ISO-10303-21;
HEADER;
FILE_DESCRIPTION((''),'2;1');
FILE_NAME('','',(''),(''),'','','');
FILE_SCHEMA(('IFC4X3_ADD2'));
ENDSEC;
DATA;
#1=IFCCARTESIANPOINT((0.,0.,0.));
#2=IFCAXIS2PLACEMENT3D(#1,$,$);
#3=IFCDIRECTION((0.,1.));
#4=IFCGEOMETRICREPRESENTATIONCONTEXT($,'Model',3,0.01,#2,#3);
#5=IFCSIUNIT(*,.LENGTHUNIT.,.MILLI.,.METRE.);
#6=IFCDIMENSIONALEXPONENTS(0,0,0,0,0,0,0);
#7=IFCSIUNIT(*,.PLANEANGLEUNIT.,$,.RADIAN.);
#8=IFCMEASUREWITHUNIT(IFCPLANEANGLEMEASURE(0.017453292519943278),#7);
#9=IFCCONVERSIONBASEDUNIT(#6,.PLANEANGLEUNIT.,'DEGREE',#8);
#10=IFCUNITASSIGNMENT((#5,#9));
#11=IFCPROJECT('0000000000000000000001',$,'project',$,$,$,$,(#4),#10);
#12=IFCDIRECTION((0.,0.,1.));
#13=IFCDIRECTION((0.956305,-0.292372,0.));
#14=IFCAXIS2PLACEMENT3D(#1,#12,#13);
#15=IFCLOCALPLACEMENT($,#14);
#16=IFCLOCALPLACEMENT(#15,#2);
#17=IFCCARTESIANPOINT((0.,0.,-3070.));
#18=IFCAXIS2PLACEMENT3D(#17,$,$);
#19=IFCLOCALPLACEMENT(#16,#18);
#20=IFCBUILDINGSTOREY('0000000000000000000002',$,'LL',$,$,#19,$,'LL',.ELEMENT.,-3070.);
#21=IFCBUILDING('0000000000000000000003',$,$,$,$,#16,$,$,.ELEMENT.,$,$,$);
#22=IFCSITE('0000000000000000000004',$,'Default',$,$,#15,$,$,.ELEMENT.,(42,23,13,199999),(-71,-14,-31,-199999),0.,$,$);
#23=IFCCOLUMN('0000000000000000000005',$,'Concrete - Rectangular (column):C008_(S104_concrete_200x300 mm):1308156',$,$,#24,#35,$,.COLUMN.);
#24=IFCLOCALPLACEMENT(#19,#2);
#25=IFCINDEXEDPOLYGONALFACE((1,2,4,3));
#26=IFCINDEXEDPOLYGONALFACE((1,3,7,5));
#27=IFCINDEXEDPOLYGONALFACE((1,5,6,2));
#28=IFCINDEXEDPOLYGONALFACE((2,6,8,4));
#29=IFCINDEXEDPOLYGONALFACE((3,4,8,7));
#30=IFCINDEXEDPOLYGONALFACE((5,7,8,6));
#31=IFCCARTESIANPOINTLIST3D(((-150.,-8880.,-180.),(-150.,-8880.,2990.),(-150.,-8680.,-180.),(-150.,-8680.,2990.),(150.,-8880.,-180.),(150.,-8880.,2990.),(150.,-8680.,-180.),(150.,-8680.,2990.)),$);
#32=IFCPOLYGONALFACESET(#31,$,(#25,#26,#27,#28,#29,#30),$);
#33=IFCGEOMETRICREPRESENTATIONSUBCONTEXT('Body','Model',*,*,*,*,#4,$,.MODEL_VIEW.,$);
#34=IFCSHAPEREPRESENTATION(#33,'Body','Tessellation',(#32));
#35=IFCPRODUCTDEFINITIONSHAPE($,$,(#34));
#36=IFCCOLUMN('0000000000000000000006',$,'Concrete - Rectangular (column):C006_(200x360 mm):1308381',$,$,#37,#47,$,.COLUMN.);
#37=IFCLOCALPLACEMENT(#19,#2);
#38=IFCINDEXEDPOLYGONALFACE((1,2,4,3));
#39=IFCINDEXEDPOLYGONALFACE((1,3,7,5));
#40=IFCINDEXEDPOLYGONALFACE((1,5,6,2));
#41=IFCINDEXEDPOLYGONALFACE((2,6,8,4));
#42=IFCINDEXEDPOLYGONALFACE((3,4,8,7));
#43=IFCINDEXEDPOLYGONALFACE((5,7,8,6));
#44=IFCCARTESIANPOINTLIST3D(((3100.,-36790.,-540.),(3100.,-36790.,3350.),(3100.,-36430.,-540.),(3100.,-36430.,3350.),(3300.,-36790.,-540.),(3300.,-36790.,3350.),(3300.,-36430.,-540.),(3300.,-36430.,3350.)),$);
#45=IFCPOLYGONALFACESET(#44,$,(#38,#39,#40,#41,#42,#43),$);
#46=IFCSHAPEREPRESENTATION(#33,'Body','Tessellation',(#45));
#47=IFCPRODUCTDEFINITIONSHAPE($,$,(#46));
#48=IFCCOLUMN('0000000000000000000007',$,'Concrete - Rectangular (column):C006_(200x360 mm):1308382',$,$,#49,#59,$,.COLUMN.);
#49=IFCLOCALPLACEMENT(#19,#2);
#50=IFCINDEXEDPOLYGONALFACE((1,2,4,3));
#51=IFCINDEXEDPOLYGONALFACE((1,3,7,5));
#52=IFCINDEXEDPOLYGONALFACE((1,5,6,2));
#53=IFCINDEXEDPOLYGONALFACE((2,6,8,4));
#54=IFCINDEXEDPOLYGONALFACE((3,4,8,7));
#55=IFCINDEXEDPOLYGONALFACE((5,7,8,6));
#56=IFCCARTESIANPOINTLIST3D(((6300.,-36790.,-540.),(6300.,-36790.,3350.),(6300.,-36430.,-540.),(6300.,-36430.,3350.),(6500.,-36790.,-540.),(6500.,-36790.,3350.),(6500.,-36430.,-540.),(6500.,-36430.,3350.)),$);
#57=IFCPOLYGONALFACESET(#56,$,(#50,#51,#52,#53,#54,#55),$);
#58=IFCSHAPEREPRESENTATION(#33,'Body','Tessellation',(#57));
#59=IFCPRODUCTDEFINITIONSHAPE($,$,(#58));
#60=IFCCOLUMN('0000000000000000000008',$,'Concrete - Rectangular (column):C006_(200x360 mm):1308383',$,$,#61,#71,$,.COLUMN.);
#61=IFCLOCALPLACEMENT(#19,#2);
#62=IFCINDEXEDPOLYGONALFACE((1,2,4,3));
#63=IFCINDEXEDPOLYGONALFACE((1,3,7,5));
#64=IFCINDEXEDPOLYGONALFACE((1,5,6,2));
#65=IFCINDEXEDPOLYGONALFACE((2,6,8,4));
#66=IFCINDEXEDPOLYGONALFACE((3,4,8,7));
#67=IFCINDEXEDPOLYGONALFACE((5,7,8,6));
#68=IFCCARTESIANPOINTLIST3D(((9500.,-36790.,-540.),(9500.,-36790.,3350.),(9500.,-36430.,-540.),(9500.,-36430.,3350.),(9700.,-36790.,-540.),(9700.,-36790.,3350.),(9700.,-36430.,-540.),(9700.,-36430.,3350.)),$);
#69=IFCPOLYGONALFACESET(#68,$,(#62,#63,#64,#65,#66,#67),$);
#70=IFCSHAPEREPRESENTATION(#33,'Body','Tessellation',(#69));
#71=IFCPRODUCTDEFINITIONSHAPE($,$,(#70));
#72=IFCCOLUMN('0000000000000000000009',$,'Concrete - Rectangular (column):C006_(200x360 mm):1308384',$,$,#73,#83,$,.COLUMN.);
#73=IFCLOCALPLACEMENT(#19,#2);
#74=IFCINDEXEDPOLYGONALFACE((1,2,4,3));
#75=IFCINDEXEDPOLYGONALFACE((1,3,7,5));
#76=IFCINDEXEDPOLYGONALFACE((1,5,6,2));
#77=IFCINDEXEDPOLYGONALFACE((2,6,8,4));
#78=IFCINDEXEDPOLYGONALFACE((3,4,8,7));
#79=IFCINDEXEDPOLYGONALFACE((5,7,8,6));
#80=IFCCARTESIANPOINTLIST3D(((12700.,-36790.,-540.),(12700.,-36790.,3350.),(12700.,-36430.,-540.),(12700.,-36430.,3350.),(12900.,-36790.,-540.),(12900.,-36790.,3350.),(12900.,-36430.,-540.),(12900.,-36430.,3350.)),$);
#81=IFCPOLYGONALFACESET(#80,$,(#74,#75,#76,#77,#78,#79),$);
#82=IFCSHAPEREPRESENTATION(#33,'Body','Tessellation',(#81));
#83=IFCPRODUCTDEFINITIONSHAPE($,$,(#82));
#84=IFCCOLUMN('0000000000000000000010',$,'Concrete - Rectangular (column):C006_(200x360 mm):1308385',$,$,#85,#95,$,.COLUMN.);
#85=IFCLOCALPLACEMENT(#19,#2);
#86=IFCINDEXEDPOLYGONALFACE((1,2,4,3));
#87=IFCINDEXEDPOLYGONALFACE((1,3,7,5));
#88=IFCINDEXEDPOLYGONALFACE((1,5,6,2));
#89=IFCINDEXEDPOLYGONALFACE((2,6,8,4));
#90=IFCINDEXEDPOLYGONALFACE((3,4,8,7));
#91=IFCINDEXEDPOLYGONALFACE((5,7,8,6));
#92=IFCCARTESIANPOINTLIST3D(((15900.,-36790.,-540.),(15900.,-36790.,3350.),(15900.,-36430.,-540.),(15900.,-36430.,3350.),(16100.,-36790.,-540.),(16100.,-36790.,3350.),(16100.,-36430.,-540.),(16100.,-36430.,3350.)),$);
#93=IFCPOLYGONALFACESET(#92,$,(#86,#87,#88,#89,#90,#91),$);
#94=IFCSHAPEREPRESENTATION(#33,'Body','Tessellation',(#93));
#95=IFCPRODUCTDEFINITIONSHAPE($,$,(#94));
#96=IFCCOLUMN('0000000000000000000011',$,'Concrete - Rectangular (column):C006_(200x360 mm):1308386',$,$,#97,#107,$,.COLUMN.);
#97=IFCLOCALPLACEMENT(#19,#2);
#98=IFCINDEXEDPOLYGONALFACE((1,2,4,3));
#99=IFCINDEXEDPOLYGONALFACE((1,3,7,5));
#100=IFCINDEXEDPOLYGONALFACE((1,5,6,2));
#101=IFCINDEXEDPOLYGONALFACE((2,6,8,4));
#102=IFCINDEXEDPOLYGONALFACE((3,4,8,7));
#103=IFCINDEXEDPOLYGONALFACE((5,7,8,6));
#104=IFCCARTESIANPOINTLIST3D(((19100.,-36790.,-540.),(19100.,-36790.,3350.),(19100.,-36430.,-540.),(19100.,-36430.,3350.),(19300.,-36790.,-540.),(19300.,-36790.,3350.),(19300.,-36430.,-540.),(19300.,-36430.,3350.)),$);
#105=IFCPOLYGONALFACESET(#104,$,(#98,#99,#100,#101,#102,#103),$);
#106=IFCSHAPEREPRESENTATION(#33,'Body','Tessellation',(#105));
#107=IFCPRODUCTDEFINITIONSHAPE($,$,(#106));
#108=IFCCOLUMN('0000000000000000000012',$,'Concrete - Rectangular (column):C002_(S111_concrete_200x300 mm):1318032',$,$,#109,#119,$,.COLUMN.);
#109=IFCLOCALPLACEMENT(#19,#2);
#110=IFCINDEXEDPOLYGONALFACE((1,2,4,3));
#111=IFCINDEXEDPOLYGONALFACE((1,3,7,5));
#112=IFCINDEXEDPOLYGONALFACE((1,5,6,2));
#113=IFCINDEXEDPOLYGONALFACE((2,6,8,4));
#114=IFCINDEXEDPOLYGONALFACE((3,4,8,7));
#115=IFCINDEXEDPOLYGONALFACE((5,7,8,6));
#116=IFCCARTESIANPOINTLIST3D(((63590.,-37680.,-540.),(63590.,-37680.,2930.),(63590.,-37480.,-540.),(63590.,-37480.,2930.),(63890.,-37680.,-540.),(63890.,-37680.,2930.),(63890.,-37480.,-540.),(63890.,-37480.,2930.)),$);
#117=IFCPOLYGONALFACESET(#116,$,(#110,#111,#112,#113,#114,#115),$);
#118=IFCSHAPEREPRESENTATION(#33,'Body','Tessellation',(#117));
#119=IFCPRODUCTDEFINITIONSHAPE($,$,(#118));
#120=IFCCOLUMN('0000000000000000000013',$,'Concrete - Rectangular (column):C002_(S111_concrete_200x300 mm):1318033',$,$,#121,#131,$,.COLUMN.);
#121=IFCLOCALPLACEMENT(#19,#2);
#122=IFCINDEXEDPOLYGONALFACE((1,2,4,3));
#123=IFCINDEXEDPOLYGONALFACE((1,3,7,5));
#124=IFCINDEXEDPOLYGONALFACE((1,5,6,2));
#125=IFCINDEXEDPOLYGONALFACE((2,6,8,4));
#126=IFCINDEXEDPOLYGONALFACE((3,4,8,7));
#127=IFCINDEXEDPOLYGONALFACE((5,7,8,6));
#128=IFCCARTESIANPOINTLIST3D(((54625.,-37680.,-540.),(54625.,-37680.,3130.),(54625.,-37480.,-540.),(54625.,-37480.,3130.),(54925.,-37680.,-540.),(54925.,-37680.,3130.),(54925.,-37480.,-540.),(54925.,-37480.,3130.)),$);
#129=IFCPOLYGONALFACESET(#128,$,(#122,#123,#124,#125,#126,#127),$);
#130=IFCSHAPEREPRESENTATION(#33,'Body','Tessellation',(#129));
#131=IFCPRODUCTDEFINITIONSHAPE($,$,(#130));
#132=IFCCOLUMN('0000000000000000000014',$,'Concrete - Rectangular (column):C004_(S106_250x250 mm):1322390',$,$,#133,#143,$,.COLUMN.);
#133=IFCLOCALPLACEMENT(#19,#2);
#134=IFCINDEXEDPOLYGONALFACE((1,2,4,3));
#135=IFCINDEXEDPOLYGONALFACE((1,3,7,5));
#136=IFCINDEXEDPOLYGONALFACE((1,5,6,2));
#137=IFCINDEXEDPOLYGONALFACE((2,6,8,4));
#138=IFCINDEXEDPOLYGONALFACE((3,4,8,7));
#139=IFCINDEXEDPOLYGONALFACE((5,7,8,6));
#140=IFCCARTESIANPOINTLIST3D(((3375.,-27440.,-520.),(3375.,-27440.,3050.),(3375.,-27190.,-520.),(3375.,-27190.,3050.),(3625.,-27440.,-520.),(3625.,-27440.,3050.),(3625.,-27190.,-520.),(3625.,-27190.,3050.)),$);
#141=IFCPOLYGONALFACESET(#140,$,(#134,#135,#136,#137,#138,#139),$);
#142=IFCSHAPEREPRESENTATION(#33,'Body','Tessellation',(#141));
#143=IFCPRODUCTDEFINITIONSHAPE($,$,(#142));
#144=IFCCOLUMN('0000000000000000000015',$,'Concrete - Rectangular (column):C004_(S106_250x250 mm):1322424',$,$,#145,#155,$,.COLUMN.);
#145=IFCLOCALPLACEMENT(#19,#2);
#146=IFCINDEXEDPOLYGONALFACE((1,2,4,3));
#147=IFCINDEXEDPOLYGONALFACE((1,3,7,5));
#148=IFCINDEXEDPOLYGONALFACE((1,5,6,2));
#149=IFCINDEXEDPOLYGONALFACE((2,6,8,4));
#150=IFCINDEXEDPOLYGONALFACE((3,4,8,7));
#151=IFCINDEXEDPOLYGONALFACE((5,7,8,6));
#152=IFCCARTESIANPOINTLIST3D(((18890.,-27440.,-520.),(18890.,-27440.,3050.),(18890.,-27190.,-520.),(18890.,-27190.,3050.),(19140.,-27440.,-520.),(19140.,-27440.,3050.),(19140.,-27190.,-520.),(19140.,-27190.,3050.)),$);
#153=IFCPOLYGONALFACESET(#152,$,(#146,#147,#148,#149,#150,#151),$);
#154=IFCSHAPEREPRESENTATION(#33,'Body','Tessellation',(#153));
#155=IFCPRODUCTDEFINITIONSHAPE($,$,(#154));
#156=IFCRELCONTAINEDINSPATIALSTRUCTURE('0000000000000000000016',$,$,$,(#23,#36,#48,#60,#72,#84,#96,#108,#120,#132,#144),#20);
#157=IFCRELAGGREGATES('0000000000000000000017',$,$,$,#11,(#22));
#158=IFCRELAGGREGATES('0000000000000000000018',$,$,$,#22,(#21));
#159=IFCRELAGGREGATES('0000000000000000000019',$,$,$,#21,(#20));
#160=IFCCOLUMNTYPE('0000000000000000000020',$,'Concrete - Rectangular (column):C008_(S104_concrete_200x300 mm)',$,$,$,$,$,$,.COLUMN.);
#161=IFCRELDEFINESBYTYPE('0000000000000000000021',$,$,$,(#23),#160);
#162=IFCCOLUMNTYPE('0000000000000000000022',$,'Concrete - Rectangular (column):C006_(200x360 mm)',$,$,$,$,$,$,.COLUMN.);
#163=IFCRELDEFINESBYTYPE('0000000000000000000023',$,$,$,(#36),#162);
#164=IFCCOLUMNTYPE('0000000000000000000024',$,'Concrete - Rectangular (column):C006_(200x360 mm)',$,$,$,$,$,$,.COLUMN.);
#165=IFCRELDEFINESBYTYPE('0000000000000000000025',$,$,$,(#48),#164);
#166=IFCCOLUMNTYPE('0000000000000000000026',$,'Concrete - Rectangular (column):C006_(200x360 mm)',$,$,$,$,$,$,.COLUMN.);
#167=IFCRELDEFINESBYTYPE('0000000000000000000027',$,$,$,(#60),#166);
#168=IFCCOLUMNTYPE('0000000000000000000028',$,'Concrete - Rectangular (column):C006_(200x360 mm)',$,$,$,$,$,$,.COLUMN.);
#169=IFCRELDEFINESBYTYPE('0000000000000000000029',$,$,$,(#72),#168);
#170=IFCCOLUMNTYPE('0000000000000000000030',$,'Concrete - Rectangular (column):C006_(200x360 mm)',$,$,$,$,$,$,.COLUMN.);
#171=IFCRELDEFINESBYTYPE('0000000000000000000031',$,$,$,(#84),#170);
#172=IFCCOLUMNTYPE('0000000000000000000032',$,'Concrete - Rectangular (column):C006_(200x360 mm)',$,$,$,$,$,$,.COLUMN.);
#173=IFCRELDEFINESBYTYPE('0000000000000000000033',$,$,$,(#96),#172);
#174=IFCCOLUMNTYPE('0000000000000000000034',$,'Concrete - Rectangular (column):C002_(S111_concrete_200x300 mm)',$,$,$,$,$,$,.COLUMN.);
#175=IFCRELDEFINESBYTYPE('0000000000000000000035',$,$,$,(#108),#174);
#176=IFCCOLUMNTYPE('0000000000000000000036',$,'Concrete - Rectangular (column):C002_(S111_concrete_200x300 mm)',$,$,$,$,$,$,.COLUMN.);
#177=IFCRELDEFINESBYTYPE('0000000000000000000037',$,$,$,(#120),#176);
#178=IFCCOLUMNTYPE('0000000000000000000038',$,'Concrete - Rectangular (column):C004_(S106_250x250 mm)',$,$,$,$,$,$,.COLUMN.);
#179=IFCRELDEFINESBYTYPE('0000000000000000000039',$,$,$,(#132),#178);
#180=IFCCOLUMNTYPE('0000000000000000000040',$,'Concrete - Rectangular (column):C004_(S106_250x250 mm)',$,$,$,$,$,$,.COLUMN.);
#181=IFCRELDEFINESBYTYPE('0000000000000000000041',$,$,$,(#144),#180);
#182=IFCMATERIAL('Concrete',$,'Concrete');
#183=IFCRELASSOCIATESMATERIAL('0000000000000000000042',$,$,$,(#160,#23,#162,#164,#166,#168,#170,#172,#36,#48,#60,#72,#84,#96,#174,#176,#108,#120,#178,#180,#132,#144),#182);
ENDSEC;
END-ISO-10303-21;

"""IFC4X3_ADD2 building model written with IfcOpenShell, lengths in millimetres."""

from ifc_helpers import new_model, entity, si_unit, converted_unit, direction, frame, frame_2d, origin, origin_2d_with_axis, place, context, subcontext, project, spatial, rectangle, extrude, source, transform, mapped, material, material_profile, profile_set, profile_usage, type_object, type_shapes, element, save


model = new_model("IFC4X3_ADD2")

# Units and contexts
model_context = context("Model", 3, precision=0.01, world=origin(), true_north=direction((0.0, 1.0)))
body_context = subcontext(model_context, "Body", "Model", "MODEL_VIEW")
ifc_project = project(units=[si_unit("LENGTHUNIT", "METRE", prefix="MILLI"), converted_unit("PLANEANGLEUNIT", "DEGREE", entity("IfcPlaneAngleMeasure", 0.017453292519943278), si_unit("PLANEANGLEUNIT", "RADIAN"), dimensions=[0, 0, 0, 0, 0, 0, 0])], contexts=[model_context])

# Site, building, storey
site_placement = place(None, frame((0.0, 0.0, 0.0), z_axis=(0.0, 0.0, 1.0), x_axis=(0.956305, -0.292372, 0.0)))
site = spatial("IfcSite", under=ifc_project, at=site_placement, Name="Default", CompositionType="ELEMENT", RefLatitude=(42, 23, 13, 199999), RefLongitude=(-71, -14, -31, -199999), RefElevation=0.0)
building_placement = place(site_placement, origin())
building = spatial("IfcBuilding", under=site, at=building_placement, CompositionType="ELEMENT")
storey_placement = place(building_placement, frame((0.0, 0.0, -3070.0)))
storey = spatial("IfcBuildingStorey", under=building, at=storey_placement, Name="LL", LongName="LL", CompositionType="ELEMENT", Elevation=-3070.0)

# Columns
ifc_material_1 = material(Name="Concrete", Category="Concrete")
ifc_material_profile_1 = material_profile(ifc_material_1, rectangle(XDim=200.0, YDim=300.0, at=frame_2d((0.0, 0.0), x_axis=(1.0, 0.0))), Name="C008_(S104_concrete_200x300 mm)")
ifc_profile_set_1 = profile_set([ifc_material_profile_1], Name="C008_(S104_concrete_200x300 mm)")
ifc_profile_usage_1 = profile_usage(ifc_profile_set_1)
column_type_1 = type_object("IfcColumnType", Name="Concrete - Rectangular (column):C008_(S104_concrete_200x300 mm)", PredefinedType="COLUMN", material=ifc_profile_set_1)
shared_shape_1 = source(origin(), body_context, "Body", "SweptSolid", [
    extrude(rectangle(XDim=200.0, YDim=300.0, at=frame_2d((0.0, 0.0), x_axis=(1.0, 0.0))), frame((0.0, -8780.0, -3250.0), z_axis=(0.0, 0.0, 1.0), x_axis=(0.0, 1.0, 0.0)), (0.0, 0.0, 1.0), 3170.0),
])
type_shapes(column_type_1, [shared_shape_1])
column_1_placement = place(storey_placement, frame((0.0, 0.0, 3070.0)))
element("IfcColumn", 1, at=column_1_placement, inside=storey, type_object=column_type_1, material=ifc_profile_usage_1, Name="Concrete - Rectangular (column):C008_(S104_concrete_200x300 mm):1308156", PredefinedType="COLUMN", context=body_context, shape_type="MappedRepresentation", body=[
    mapped(shared_shape_1, transform((0.0, 0.0, 0.0), scale=1.0)),
])
ifc_material_profile_2 = material_profile(ifc_material_1, rectangle(XDim=200.0, YDim=360.0, at=frame_2d((0.0, 0.0), x_axis=(1.0, 0.0))), Name="C006_(200x360 mm)")
ifc_profile_set_2 = profile_set([ifc_material_profile_2], Name="C006_(200x360 mm)")
ifc_profile_usage_2 = profile_usage(ifc_profile_set_2)
column_type_2 = type_object("IfcColumnType", Name="Concrete - Rectangular (column):C006_(200x360 mm)", PredefinedType="COLUMN", material=ifc_profile_set_2)
shared_shape_2 = source(origin(), body_context, "Body", "SweptSolid", [
    extrude(rectangle(XDim=200.0, YDim=360.0, at=frame_2d((0.0, 0.0), x_axis=(1.0, 0.0))), frame((3200.0, -36610.0, -3610.0), z_axis=(0.0, 0.0, 1.0), x_axis=(-1.0, 0.0, 0.0)), (0.0, 0.0, 1.0), 3890.0),
])
type_shapes(column_type_2, [shared_shape_2])
column_2_placement = place(storey_placement, frame((0.0, 0.0, 3070.0)))
element("IfcColumn", 2, at=column_2_placement, inside=storey, type_object=column_type_2, material=ifc_profile_usage_2, Name="Concrete - Rectangular (column):C006_(200x360 mm):1308381", PredefinedType="COLUMN", context=body_context, shape_type="MappedRepresentation", body=[
    mapped(shared_shape_2, transform((0.0, 0.0, 0.0), scale=1.0)),
])
column_type_3 = type_object("IfcColumnType", Name="Concrete - Rectangular (column):C006_(200x360 mm)", PredefinedType="COLUMN", material=ifc_profile_set_2)
shared_shape_3 = source(origin(), body_context, "Body", "SweptSolid", [
    extrude(rectangle(XDim=200.0, YDim=360.0, at=frame_2d((0.0, 0.0), x_axis=(1.0, 0.0))), frame((6400.0, -36610.0, -3610.0), z_axis=(0.0, 0.0, 1.0), x_axis=(-1.0, 0.0, 0.0)), (0.0, 0.0, 1.0), 3890.0),
])
type_shapes(column_type_3, [shared_shape_3])
column_3_placement = place(storey_placement, frame((0.0, 0.0, 3070.0)))
element("IfcColumn", 3, at=column_3_placement, inside=storey, type_object=column_type_3, material=ifc_profile_usage_2, Name="Concrete - Rectangular (column):C006_(200x360 mm):1308382", PredefinedType="COLUMN", context=body_context, shape_type="MappedRepresentation", body=[
    mapped(shared_shape_3, transform((0.0, 0.0, 0.0), scale=1.0)),
])
column_type_4 = type_object("IfcColumnType", Name="Concrete - Rectangular (column):C006_(200x360 mm)", PredefinedType="COLUMN", material=ifc_profile_set_2)
shared_shape_4 = source(origin(), body_context, "Body", "SweptSolid", [
    extrude(rectangle(XDim=200.0, YDim=360.0, at=frame_2d((0.0, 0.0), x_axis=(1.0, 0.0))), frame((9600.0, -36610.0, -3610.0), z_axis=(0.0, 0.0, 1.0), x_axis=(-1.0, 0.0, 0.0)), (0.0, 0.0, 1.0), 3890.0),
])
type_shapes(column_type_4, [shared_shape_4])
column_4_placement = place(storey_placement, frame((0.0, 0.0, 3070.0)))
element("IfcColumn", 4, at=column_4_placement, inside=storey, type_object=column_type_4, material=ifc_profile_usage_2, Name="Concrete - Rectangular (column):C006_(200x360 mm):1308383", PredefinedType="COLUMN", context=body_context, shape_type="MappedRepresentation", body=[
    mapped(shared_shape_4, transform((0.0, 0.0, 0.0), scale=1.0)),
])
column_type_5 = type_object("IfcColumnType", Name="Concrete - Rectangular (column):C006_(200x360 mm)", PredefinedType="COLUMN", material=ifc_profile_set_2)
shared_shape_5 = source(origin(), body_context, "Body", "SweptSolid", [
    extrude(rectangle(XDim=200.0, YDim=360.0, at=frame_2d((0.0, 0.0), x_axis=(1.0, 0.0))), frame((12800.0, -36610.0, -3610.0), z_axis=(0.0, 0.0, 1.0), x_axis=(-1.0, 0.0, 0.0)), (0.0, 0.0, 1.0), 3890.0),
])
type_shapes(column_type_5, [shared_shape_5])
column_5_placement = place(storey_placement, frame((0.0, 0.0, 3070.0)))
element("IfcColumn", 5, at=column_5_placement, inside=storey, type_object=column_type_5, material=ifc_profile_usage_2, Name="Concrete - Rectangular (column):C006_(200x360 mm):1308384", PredefinedType="COLUMN", context=body_context, shape_type="MappedRepresentation", body=[
    mapped(shared_shape_5, transform((0.0, 0.0, 0.0), scale=1.0)),
])
column_type_6 = type_object("IfcColumnType", Name="Concrete - Rectangular (column):C006_(200x360 mm)", PredefinedType="COLUMN", material=ifc_profile_set_2)
shared_shape_6 = source(origin(), body_context, "Body", "SweptSolid", [
    extrude(rectangle(XDim=200.0, YDim=360.0, at=frame_2d((0.0, 0.0), x_axis=(1.0, 0.0))), frame((16000.0, -36610.0, -3610.0), z_axis=(0.0, 0.0, 1.0), x_axis=(-1.0, 0.0, 0.0)), (0.0, 0.0, 1.0), 3890.0),
])
type_shapes(column_type_6, [shared_shape_6])
column_6_placement = place(storey_placement, frame((0.0, 0.0, 3070.0)))
element("IfcColumn", 6, at=column_6_placement, inside=storey, type_object=column_type_6, material=ifc_profile_usage_2, Name="Concrete - Rectangular (column):C006_(200x360 mm):1308385", PredefinedType="COLUMN", context=body_context, shape_type="MappedRepresentation", body=[
    mapped(shared_shape_6, transform((0.0, 0.0, 0.0), scale=1.0)),
])
column_type_7 = type_object("IfcColumnType", Name="Concrete - Rectangular (column):C006_(200x360 mm)", PredefinedType="COLUMN", material=ifc_profile_set_2)
shared_shape_7 = source(origin(), body_context, "Body", "SweptSolid", [
    extrude(rectangle(XDim=200.0, YDim=360.0, at=frame_2d((0.0, 0.0), x_axis=(1.0, 0.0))), frame((19200.0, -36610.0, -3610.0), z_axis=(0.0, 0.0, 1.0), x_axis=(-1.0, 0.0, 0.0)), (0.0, 0.0, 1.0), 3890.0),
])
type_shapes(column_type_7, [shared_shape_7])
column_7_placement = place(storey_placement, frame((0.0, 0.0, 3070.0)))
element("IfcColumn", 7, at=column_7_placement, inside=storey, type_object=column_type_7, material=ifc_profile_usage_2, Name="Concrete - Rectangular (column):C006_(200x360 mm):1308386", PredefinedType="COLUMN", context=body_context, shape_type="MappedRepresentation", body=[
    mapped(shared_shape_7, transform((0.0, 0.0, 0.0), scale=1.0)),
])
ifc_material_profile_3 = material_profile(ifc_material_1, rectangle(XDim=300.0, YDim=200.0, at=frame_2d((0.0, 0.0), x_axis=(1.0, 0.0))), Name="C002_(S111_concrete_200x300 mm)")
ifc_profile_set_3 = profile_set([ifc_material_profile_3], Name="C002_(S111_concrete_200x300 mm)")
ifc_profile_usage_3 = profile_usage(ifc_profile_set_3)
column_type_8 = type_object("IfcColumnType", Name="Concrete - Rectangular (column):C002_(S111_concrete_200x300 mm)", PredefinedType="COLUMN", material=ifc_profile_set_3)
shared_shape_8 = source(origin(), body_context, "Body", "SweptSolid", [
    extrude(rectangle(XDim=300.0, YDim=200.0, at=origin_2d_with_axis()), frame((63740.0, -37580.0, -3610.0), z_axis=(0.0, 0.0, 1.0), x_axis=(-1.0, 0.0, 0.0)), (0.0, 0.0, 1.0), 3470.0),
])
type_shapes(column_type_8, [shared_shape_8])
column_8_placement = place(storey_placement, frame((0.0, 0.0, 3070.0)))
element("IfcColumn", 8, at=column_8_placement, inside=storey, type_object=column_type_8, material=ifc_profile_usage_3, Name="Concrete - Rectangular (column):C002_(S111_concrete_200x300 mm):1318032", PredefinedType="COLUMN", context=body_context, shape_type="MappedRepresentation", body=[
    mapped(shared_shape_8, transform((0.0, 0.0, 0.0), scale=1.0)),
])
column_type_9 = type_object("IfcColumnType", Name="Concrete - Rectangular (column):C002_(S111_concrete_200x300 mm)", PredefinedType="COLUMN", material=ifc_profile_set_3)
shared_shape_9 = source(origin(), body_context, "Body", "SweptSolid", [
    extrude(rectangle(XDim=300.0, YDim=200.0, at=origin_2d_with_axis()), frame((54775.0, -37580.0, -3610.0), z_axis=(0.0, 0.0, 1.0), x_axis=(-1.0, 0.0, 0.0)), (0.0, 0.0, 1.0), 3670.0),
])
type_shapes(column_type_9, [shared_shape_9])
column_9_placement = place(storey_placement, frame((0.0, 0.0, 3070.0)))
element("IfcColumn", 9, at=column_9_placement, inside=storey, type_object=column_type_9, material=ifc_profile_usage_3, Name="Concrete - Rectangular (column):C002_(S111_concrete_200x300 mm):1318033", PredefinedType="COLUMN", context=body_context, shape_type="MappedRepresentation", body=[
    mapped(shared_shape_9, transform((0.0, 0.0, 0.0), scale=1.0)),
])
ifc_material_profile_4 = material_profile(ifc_material_1, rectangle(XDim=250.0, YDim=250.0, at=frame_2d((0.0, 0.0), x_axis=(1.0, 0.0))), Name="C004_(S106_250x250 mm)")
ifc_profile_set_4 = profile_set([ifc_material_profile_4], Name="C004_(S106_250x250 mm)")
ifc_profile_usage_4 = profile_usage(ifc_profile_set_4)
column_type_10 = type_object("IfcColumnType", Name="Concrete - Rectangular (column):C004_(S106_250x250 mm)", PredefinedType="COLUMN", material=ifc_profile_set_4)
shared_shape_10 = source(origin(), body_context, "Body", "SweptSolid", [
    extrude(rectangle(XDim=250.0, YDim=250.0, at=frame_2d((0.0, 0.0), x_axis=(1.0, 0.0))), frame((3500.0, -27315.0, -3590.0), z_axis=(0.0, 0.0, 1.0), x_axis=(-1.0, 0.0, 0.0)), (0.0, 0.0, 1.0), 3570.0),
])
type_shapes(column_type_10, [shared_shape_10])
column_10_placement = place(storey_placement, frame((0.0, 0.0, 3070.0)))
element("IfcColumn", 10, at=column_10_placement, inside=storey, type_object=column_type_10, material=ifc_profile_usage_4, Name="Concrete - Rectangular (column):C004_(S106_250x250 mm):1322390", PredefinedType="COLUMN", context=body_context, shape_type="MappedRepresentation", body=[
    mapped(shared_shape_10, transform((0.0, 0.0, 0.0), scale=1.0)),
])
column_type_11 = type_object("IfcColumnType", Name="Concrete - Rectangular (column):C004_(S106_250x250 mm)", PredefinedType="COLUMN", material=ifc_profile_set_4)
shared_shape_11 = source(origin(), body_context, "Body", "SweptSolid", [
    extrude(rectangle(XDim=250.0, YDim=250.0, at=frame_2d((0.0, 0.0), x_axis=(1.0, 0.0))), frame((19015.0, -27315.0, -3590.0), z_axis=(0.0, 0.0, 1.0), x_axis=(-1.0, 0.0, 0.0)), (0.0, 0.0, 1.0), 3570.0),
])
type_shapes(column_type_11, [shared_shape_11])
column_11_placement = place(storey_placement, frame((0.0, 0.0, 3070.0)))
element("IfcColumn", 11, at=column_11_placement, inside=storey, type_object=column_type_11, material=ifc_profile_usage_4, Name="Concrete - Rectangular (column):C004_(S106_250x250 mm):1322424", PredefinedType="COLUMN", context=body_context, shape_type="MappedRepresentation", body=[
    mapped(shared_shape_11, transform((0.0, 0.0, 0.0), scale=1.0)),
])

save(model, "model.ifc")
